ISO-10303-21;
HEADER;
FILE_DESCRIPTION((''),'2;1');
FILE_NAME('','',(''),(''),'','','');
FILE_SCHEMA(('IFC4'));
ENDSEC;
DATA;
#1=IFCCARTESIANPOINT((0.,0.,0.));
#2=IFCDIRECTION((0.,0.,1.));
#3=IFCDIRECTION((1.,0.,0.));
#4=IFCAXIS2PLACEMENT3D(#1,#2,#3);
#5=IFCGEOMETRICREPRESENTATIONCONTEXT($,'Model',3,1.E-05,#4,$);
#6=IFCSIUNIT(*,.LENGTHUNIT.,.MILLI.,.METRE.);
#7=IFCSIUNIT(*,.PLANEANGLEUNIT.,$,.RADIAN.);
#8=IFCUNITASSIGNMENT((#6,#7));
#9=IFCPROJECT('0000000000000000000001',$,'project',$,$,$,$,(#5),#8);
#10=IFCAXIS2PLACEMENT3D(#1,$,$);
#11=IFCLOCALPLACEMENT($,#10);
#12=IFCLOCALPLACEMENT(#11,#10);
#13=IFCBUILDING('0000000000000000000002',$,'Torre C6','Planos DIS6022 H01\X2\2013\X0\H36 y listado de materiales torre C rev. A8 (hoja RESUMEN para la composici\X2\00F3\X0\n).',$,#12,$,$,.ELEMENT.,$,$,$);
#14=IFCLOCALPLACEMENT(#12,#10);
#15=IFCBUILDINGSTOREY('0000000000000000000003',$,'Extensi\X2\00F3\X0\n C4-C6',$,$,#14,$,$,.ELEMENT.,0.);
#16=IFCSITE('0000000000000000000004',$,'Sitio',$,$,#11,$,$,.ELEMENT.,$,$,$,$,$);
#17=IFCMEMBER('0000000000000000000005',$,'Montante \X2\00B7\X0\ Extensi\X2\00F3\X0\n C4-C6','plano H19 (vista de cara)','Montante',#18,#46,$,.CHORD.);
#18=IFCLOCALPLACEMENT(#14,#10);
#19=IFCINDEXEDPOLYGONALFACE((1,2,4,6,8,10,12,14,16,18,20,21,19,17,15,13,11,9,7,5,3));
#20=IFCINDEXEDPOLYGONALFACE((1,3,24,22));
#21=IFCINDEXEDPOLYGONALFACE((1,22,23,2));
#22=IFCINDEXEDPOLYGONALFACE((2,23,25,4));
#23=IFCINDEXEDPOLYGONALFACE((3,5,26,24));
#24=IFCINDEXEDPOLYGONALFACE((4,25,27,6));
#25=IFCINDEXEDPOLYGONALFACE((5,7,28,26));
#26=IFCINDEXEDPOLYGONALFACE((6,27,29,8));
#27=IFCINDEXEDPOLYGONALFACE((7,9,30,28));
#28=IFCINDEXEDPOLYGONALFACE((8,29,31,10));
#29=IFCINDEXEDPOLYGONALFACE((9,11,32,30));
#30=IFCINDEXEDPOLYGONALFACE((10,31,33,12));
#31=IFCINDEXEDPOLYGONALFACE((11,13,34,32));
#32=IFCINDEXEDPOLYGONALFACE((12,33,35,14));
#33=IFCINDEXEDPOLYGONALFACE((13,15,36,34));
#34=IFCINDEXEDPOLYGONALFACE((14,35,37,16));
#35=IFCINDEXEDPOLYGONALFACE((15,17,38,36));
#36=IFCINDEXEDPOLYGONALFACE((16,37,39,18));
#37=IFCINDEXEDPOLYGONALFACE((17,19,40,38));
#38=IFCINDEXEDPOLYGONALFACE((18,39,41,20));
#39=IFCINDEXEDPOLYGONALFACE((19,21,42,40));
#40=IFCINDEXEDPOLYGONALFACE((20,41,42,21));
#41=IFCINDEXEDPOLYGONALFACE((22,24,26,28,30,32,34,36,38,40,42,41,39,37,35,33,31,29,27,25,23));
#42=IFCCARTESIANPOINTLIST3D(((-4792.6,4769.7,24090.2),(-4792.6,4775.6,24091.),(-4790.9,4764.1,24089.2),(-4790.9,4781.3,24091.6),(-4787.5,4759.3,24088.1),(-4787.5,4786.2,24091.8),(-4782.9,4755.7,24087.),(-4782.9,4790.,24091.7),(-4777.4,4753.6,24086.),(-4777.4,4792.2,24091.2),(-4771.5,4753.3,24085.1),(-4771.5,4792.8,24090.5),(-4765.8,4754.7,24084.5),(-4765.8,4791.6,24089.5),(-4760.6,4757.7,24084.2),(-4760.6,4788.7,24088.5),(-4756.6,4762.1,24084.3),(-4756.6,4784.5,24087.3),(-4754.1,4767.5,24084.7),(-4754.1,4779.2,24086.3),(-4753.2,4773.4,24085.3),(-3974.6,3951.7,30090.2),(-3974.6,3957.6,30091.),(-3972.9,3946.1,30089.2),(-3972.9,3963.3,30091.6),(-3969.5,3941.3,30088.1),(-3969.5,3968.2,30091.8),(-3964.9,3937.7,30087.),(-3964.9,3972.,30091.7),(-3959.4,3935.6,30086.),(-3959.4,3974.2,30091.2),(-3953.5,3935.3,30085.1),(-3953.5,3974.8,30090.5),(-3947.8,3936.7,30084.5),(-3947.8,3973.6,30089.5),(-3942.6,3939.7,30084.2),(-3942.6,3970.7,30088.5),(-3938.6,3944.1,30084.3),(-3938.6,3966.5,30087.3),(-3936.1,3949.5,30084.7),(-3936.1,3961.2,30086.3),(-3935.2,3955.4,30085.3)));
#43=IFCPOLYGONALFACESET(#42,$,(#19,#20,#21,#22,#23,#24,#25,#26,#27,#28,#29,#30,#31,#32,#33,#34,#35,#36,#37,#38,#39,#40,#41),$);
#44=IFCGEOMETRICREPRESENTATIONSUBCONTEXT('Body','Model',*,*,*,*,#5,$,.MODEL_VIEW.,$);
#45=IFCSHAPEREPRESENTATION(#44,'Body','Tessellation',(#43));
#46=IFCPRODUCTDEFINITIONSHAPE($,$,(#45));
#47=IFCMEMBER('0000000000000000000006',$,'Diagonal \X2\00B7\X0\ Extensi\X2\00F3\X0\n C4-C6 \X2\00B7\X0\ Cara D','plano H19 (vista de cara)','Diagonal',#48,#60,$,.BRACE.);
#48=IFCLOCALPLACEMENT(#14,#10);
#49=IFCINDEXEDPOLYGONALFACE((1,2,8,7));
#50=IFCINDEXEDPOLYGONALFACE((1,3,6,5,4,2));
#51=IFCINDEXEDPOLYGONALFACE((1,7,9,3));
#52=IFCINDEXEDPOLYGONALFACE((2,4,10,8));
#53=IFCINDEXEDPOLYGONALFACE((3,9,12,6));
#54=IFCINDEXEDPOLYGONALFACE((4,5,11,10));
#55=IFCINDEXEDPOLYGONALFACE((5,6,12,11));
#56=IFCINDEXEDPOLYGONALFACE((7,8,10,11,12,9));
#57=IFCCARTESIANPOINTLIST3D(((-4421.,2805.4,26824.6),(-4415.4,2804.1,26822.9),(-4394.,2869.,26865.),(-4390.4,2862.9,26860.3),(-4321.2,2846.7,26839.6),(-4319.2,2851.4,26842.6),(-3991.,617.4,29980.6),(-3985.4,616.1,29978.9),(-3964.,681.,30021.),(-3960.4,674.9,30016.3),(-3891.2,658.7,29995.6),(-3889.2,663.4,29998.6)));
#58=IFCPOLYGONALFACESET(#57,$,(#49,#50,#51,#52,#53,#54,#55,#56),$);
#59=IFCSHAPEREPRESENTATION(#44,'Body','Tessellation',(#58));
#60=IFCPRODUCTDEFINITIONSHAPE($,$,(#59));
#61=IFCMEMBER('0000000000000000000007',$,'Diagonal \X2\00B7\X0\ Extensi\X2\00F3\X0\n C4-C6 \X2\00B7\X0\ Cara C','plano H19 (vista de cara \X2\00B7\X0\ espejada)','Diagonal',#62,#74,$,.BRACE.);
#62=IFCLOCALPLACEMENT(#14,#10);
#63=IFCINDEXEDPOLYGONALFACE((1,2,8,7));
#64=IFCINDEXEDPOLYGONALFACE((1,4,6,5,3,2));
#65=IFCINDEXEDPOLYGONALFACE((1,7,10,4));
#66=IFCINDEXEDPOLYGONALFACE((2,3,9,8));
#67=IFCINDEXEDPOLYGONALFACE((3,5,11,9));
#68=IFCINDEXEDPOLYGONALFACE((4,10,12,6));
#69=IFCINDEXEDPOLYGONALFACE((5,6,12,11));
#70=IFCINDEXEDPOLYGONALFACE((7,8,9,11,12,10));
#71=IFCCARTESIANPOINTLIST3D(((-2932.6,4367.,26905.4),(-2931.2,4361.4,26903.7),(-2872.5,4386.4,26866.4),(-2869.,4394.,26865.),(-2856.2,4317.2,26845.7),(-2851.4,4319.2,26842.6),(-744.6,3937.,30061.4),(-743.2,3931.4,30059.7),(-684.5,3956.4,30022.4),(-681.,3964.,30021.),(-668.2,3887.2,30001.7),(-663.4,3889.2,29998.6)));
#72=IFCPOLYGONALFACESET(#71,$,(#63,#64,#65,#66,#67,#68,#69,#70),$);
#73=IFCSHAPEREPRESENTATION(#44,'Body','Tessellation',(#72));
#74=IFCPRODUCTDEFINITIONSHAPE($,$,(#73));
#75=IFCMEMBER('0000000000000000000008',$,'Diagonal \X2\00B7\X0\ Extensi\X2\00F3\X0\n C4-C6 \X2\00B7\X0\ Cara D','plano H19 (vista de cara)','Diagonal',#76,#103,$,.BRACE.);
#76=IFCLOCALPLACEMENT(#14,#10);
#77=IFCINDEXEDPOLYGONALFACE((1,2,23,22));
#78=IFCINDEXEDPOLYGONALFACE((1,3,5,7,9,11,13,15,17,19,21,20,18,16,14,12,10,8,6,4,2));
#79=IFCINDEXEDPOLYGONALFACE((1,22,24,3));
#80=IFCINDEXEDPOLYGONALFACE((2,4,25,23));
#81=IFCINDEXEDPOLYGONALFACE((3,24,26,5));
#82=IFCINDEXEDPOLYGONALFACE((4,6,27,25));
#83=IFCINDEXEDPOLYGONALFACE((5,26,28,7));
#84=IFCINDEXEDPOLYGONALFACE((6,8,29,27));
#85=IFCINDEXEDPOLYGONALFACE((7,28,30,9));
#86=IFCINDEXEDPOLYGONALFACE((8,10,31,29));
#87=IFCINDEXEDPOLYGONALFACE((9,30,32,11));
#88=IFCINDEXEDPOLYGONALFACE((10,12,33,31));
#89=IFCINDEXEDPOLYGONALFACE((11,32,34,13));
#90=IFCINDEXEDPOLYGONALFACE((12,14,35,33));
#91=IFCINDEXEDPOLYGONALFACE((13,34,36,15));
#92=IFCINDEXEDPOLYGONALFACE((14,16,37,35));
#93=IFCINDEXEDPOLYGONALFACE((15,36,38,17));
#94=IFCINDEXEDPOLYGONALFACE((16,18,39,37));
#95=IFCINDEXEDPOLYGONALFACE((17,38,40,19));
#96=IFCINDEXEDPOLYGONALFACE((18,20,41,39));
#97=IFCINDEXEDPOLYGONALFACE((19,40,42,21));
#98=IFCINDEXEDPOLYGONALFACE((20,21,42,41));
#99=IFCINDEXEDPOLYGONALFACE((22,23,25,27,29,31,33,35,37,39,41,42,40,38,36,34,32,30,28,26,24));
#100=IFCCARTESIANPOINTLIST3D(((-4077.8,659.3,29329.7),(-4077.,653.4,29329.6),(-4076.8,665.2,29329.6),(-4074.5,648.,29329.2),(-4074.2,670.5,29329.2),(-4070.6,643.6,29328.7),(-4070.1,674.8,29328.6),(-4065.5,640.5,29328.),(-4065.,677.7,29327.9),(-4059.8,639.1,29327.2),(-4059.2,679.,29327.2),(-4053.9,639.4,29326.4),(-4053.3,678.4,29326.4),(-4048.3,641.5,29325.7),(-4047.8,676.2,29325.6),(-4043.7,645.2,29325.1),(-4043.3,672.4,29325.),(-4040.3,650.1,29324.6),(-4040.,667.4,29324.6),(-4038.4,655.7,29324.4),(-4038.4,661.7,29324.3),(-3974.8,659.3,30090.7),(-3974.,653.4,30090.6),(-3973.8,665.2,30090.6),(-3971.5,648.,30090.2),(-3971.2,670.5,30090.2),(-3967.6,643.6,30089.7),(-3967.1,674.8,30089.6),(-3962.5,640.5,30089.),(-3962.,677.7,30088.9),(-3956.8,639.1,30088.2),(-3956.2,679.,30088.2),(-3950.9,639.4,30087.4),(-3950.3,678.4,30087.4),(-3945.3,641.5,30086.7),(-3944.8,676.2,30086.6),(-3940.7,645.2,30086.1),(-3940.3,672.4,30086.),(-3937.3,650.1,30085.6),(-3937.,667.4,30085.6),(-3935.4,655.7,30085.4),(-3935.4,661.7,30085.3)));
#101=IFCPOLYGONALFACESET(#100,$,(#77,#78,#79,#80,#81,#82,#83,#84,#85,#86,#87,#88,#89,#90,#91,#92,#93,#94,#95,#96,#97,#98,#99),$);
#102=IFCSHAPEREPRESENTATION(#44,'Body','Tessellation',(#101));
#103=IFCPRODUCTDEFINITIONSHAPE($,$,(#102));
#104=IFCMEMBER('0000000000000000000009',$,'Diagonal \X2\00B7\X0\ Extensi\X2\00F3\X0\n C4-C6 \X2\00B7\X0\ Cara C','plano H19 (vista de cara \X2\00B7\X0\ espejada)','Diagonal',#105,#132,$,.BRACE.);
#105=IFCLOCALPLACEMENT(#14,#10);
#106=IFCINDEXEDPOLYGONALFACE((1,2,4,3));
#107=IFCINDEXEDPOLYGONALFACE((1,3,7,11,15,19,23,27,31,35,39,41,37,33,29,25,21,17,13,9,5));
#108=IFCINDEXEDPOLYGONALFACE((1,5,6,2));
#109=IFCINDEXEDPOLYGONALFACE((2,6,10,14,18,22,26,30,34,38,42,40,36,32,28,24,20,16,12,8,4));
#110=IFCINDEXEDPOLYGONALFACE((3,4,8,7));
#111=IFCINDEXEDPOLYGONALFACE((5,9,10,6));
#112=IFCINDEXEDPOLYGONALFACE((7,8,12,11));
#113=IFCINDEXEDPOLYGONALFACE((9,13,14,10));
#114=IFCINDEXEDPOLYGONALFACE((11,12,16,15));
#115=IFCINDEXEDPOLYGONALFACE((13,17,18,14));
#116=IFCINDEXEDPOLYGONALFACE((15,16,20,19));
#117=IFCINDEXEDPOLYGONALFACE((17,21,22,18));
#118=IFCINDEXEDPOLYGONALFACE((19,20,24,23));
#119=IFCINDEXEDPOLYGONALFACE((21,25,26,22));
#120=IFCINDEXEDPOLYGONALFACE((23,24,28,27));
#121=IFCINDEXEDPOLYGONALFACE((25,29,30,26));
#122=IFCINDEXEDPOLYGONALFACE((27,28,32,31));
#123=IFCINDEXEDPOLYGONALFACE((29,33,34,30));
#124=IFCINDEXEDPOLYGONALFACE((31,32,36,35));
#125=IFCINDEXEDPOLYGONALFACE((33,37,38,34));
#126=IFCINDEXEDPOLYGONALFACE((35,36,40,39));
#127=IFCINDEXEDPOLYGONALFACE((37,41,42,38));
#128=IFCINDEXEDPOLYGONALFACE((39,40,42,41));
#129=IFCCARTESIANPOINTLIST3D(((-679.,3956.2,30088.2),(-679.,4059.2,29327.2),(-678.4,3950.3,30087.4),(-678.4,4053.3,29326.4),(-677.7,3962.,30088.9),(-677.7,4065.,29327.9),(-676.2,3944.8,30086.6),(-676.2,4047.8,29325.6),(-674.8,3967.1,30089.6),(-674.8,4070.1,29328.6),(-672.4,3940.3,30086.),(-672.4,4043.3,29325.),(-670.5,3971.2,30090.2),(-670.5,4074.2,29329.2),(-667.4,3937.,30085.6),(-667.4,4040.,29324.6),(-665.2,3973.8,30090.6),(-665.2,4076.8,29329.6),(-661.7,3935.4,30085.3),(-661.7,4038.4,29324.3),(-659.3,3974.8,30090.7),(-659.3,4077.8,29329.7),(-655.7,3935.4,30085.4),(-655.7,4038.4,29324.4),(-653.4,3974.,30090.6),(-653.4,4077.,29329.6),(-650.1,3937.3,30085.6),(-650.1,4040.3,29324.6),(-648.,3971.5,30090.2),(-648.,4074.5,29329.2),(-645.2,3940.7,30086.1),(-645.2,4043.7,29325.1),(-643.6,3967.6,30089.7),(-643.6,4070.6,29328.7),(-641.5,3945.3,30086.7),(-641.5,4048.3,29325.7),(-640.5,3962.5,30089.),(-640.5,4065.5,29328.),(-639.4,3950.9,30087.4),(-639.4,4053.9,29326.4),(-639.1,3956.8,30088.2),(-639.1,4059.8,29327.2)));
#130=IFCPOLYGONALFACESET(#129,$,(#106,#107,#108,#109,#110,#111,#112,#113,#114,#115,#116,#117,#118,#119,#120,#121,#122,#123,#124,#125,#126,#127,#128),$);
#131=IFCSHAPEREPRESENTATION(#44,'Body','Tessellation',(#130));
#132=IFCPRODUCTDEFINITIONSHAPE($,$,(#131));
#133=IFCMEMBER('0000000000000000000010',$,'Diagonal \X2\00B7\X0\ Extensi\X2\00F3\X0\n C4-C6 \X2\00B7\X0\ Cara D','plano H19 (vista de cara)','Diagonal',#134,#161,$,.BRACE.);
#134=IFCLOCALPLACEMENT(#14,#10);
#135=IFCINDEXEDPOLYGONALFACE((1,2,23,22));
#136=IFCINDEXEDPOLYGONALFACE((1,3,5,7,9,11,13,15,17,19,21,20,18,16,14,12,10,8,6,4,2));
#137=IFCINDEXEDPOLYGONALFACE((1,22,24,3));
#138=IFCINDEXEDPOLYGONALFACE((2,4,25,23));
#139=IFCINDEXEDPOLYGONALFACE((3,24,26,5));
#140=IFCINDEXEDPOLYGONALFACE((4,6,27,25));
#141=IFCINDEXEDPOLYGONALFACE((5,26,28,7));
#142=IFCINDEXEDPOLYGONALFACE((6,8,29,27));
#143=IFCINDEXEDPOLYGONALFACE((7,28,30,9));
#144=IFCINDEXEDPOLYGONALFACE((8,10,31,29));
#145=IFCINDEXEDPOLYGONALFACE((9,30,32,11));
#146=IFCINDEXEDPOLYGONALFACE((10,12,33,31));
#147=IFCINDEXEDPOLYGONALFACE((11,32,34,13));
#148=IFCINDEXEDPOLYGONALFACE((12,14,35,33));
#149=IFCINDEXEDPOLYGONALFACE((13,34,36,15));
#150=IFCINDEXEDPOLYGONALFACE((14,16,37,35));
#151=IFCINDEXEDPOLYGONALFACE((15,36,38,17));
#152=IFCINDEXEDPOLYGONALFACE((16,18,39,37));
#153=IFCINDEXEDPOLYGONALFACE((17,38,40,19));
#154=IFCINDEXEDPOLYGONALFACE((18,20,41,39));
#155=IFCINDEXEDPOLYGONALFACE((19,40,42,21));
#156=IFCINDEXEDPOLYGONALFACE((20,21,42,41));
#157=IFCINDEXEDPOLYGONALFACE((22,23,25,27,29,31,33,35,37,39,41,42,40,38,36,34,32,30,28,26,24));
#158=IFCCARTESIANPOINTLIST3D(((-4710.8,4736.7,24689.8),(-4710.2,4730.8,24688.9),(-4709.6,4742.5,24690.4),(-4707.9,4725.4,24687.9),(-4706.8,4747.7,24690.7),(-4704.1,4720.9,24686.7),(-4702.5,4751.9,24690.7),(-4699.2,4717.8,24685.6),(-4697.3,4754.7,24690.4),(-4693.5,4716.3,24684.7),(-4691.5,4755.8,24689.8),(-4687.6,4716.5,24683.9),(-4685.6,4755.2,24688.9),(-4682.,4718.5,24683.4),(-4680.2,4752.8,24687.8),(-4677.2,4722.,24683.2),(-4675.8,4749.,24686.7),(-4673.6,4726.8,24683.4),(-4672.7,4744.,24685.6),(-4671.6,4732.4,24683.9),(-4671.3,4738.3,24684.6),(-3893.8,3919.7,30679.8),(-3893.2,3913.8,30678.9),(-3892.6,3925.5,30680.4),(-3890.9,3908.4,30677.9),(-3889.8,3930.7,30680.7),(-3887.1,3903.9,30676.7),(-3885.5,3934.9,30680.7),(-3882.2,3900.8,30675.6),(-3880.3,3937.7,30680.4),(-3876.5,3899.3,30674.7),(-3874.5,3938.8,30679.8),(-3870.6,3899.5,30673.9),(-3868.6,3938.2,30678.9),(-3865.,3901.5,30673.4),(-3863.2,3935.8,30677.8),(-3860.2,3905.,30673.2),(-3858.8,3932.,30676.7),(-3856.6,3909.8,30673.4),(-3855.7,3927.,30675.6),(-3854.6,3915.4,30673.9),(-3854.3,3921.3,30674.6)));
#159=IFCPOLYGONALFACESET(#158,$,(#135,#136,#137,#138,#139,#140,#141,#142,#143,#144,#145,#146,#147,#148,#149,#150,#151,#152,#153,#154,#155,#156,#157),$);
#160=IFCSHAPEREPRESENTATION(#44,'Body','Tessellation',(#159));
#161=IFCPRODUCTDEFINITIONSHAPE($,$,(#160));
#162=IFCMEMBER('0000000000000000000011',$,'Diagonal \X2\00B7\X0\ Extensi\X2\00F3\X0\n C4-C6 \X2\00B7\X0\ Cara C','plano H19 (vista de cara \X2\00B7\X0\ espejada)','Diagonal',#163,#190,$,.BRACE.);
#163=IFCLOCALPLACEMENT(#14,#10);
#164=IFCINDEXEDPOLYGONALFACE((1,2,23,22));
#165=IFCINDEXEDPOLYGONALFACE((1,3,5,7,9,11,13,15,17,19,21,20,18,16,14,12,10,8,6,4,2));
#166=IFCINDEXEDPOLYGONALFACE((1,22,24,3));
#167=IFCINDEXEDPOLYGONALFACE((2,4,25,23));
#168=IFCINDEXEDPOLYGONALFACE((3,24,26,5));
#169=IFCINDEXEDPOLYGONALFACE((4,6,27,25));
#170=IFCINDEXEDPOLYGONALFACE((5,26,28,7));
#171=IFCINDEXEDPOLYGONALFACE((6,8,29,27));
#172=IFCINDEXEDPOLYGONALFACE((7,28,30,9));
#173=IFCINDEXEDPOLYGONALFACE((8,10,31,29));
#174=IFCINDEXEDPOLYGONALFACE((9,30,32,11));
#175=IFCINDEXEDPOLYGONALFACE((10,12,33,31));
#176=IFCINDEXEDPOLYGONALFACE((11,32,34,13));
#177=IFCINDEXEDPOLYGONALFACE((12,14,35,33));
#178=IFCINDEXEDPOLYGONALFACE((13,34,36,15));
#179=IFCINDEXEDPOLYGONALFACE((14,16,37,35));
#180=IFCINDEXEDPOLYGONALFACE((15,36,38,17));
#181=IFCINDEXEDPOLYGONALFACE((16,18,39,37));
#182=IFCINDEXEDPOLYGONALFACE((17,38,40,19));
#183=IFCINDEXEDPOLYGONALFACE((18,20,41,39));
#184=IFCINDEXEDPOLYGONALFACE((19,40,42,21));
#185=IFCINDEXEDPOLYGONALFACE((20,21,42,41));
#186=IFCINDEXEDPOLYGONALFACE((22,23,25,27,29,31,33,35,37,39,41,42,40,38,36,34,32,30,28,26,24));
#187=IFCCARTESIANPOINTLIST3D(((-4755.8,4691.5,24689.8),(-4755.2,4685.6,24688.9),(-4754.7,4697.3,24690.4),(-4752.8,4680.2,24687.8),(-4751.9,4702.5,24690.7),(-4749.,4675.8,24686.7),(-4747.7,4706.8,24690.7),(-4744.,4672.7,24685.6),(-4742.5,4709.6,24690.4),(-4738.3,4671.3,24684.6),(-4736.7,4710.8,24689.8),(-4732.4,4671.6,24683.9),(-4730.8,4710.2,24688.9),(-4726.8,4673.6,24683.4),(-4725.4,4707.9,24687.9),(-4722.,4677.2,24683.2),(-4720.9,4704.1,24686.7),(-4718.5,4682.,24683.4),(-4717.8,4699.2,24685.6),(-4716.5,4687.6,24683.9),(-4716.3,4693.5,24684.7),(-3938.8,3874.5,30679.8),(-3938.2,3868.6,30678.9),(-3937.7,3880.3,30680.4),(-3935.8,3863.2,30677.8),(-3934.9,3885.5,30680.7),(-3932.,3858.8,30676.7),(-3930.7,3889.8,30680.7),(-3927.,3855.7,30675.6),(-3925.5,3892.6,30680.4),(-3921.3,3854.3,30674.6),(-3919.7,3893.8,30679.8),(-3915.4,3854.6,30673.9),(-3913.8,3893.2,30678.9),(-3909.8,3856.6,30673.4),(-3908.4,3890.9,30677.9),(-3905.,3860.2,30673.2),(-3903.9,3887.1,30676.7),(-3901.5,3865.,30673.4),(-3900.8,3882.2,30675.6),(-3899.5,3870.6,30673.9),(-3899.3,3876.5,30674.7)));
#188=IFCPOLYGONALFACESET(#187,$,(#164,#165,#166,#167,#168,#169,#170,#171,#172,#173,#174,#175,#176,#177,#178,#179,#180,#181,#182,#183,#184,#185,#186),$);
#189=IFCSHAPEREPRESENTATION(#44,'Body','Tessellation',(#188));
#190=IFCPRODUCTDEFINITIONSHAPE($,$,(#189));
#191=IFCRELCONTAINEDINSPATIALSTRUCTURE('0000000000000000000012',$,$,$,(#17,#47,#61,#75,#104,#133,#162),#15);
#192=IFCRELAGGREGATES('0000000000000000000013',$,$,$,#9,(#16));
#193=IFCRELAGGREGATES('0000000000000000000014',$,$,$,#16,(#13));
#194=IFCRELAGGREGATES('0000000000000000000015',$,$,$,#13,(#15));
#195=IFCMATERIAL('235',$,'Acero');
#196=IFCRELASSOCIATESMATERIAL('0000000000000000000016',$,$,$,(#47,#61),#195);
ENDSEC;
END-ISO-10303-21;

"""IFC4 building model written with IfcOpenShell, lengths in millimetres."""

from ifc_helpers import new_model, si_unit, frame, frame_2d, origin, origin_with_axes, place, context, subcontext, project, spatial, circle, l_section, extrude, material, element, save


model = new_model("IFC4")

# Units and contexts
model_context = context("Model", 3, precision=1e-05, world=origin_with_axes())
body_context = subcontext(model_context, "Body", "Model", "MODEL_VIEW")
ifc_project = project(units=[si_unit("LENGTHUNIT", "METRE", prefix="MILLI"), si_unit("PLANEANGLEUNIT", "RADIAN")], contexts=[model_context])

# Site, building, storey
site_placement = place(None, origin())
site = spatial("IfcSite", under=ifc_project, at=site_placement, Name="Sitio", CompositionType="ELEMENT")
building_placement = place(site_placement, origin())
building = spatial("IfcBuilding", under=site, at=building_placement, Name="Torre C6", Description="Planos DIS6022 H01–H36 y listado de materiales torre C rev. A8 (hoja RESUMEN para la composición).", CompositionType="ELEMENT")
storey_placement = place(building_placement, origin())
storey = spatial("IfcBuildingStorey", under=building, at=storey_placement, Name="Extensión C4-C6", CompositionType="ELEMENT", Elevation=0.0)

# Members
member_placement = place(storey_placement, frame((-3955.0, 3955.0, 30088.0), z_axis=(-0.133868, 0.133868, -0.981916), x_axis=(0.990999, 0.018083, -0.132641)))
element("IfcMember", 1, at=member_placement, inside=storey, Name="Montante · Extensión C4-C6", Description="plano H19 (vista de cara)", ObjectType="Montante", PredefinedType="CHORD", context=body_context, shape_type="SweptSolid", body=[
    extrude(circle(Radius=20.0), None, (0.0, 0.0, 1.0), 6110.5),
])
ifc_material = material(Name="235", Category="Acero")
for number, where, z_axis, x_axis, name, description in (
    (2, (-3964.0, 681.0, 30021.0), (-0.111276, 0.566213, -0.816713), (0.934738, -0.219434, -0.279487), "Diagonal · Extensión C4-C6 · Cara D", "plano H19 (vista de cara)"),
    (3, (-681.0, 3964.0, 30021.0), (-0.566213, 0.111276, -0.816713), (0.219434, -0.934738, -0.279487), "Diagonal · Extensión C4-C6 · Cara C", "plano H19 (vista de cara · espejada)"),
):
    element("IfcMember", number, at=place(storey_placement, frame(where, z_axis=z_axis, x_axis=x_axis)), inside=storey, material=ifc_material, Name=name, Description=description, ObjectType="Diagonal", PredefinedType="BRACE", context=body_context, shape_type="SweptSolid", body=[
        extrude(l_section(Depth=80.0, Width=80.0, Thickness=6.0, at=frame_2d((40.0, 40.0))), None, (0.0, 0.0, 1.0), 3864.3),
    ])
for number, where, z_axis, x_axis, name, description in (
    (4, (-4058.0, 659.0, 29327.0), (0.134125, 0.0, 0.990964), (0.977589, -0.163742, -0.132315), "Diagonal · Extensión C4-C6 · Cara D", "plano H19 (vista de cara)"),
    (5, (-659.0, 4058.0, 29327.0), (0.0, -0.134125, 0.990964), (0.163742, -0.977589, -0.132315), "Diagonal · Extensión C4-C6 · Cara C", "plano H19 (vista de cara · espejada)"),
):
    element("IfcMember", number, at=place(storey_placement, frame(where, z_axis=z_axis, x_axis=x_axis)), inside=storey, Name=name, Description=description, ObjectType="Diagonal", PredefinedType="BRACE", context=body_context, shape_type="SweptSolid", body=[
        extrude(circle(Radius=20.0), None, (0.0, 0.0, 1.0), 767.9),
    ])
for number, where, z_axis, x_axis, name, description in (
    (6, (-4691.0, 4736.0, 24687.0), (0.133925, -0.133925, 0.9819), (0.690535, -0.698062, -0.189396), "Diagonal · Extensión C4-C6 · Cara D", "plano H19 (vista de cara)"),
    (7, (-4736.0, 4691.0, 24687.0), (0.133925, -0.133925, 0.9819), (0.698062, -0.690535, -0.189396), "Diagonal · Extensión C4-C6 · Cara C", "plano H19 (vista de cara · espejada)"),
):
    element("IfcMember", number, at=place(storey_placement, frame(where, z_axis=z_axis, x_axis=x_axis)), inside=storey, Name=name, Description=description, ObjectType="Diagonal", PredefinedType="BRACE", context=body_context, shape_type="SweptSolid", body=[
        extrude(circle(Radius=20.0), None, (0.0, 0.0, 1.0), 6100.4),
    ])

save(model, "model.ifc")
